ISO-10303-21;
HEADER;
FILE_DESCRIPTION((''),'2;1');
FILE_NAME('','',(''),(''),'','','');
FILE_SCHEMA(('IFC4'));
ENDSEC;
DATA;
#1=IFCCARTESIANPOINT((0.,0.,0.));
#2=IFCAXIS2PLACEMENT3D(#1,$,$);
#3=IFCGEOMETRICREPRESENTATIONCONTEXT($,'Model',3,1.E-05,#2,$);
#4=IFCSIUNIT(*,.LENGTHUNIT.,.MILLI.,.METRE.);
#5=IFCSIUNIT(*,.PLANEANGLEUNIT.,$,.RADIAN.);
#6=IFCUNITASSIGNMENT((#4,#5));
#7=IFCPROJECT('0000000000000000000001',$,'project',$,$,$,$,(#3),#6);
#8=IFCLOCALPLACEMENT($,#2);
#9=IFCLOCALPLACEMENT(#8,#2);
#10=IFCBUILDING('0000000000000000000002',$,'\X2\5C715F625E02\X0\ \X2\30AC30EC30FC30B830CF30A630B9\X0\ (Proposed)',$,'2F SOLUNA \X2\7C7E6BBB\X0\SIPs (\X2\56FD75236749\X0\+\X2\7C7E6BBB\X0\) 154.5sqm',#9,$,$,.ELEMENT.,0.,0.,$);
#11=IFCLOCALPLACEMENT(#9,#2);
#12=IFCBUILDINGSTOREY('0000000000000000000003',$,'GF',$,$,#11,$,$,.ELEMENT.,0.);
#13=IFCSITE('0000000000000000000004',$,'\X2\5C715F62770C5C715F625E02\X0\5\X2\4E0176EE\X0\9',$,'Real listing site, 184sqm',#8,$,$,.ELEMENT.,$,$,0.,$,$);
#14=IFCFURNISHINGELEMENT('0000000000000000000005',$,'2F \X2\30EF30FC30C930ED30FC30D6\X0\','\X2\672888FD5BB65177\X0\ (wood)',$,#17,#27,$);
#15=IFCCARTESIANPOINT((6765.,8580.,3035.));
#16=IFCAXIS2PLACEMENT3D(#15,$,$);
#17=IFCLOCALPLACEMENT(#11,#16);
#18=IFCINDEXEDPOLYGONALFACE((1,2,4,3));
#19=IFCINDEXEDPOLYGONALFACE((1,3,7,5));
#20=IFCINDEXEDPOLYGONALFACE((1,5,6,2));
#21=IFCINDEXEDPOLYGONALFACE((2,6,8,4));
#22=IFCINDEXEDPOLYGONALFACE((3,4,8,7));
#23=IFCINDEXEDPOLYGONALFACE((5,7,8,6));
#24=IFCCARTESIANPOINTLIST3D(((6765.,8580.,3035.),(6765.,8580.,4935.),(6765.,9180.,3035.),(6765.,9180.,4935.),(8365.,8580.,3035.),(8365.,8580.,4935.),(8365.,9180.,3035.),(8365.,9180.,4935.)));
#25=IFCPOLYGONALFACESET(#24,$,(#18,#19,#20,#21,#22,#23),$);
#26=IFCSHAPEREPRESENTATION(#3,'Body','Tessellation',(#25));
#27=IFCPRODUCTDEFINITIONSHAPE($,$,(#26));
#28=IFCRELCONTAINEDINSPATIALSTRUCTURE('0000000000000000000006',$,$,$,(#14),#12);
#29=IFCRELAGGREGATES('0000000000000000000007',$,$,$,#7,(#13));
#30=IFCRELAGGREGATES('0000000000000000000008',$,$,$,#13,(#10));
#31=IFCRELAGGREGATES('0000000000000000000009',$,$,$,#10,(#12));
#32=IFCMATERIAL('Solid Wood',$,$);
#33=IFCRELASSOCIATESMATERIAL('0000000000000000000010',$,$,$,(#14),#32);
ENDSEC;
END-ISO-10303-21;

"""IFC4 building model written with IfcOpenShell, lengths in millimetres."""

from ifc_helpers import new_model, si_unit, frame, frame_2d, origin, place, context, project, spatial, rectangle, extrude, material, element, save


model = new_model("IFC4")

# Units and contexts
model_context = context("Model", 3, precision=1e-05, world=origin())
ifc_project = project(units=[si_unit("LENGTHUNIT", "METRE", prefix="MILLI"), si_unit("PLANEANGLEUNIT", "RADIAN")], contexts=[model_context])

# Site, building, storey
site_placement = place(None, origin())
site = spatial("IfcSite", under=ifc_project, at=site_placement, Name="山形県山形市5丁目9", ObjectType="Real listing site, 184sqm", CompositionType="ELEMENT", RefElevation=0.0)
building_placement = place(site_placement, origin())
building = spatial("IfcBuilding", under=site, at=building_placement, Name="山形市 ガレージハウス (Proposed)", ObjectType="2F SOLUNA 籾殻SIPs (国産杉+籾殻) 154.5sqm", CompositionType="ELEMENT", ElevationOfRefHeight=0.0, ElevationOfTerrain=0.0)
storey_placement = place(building_placement, origin())
storey = spatial("IfcBuildingStorey", under=building, at=storey_placement, Name="GF", CompositionType="ELEMENT", Elevation=0.0)

# Shared definitions
ifc_material_1 = material(Name="Solid Wood")

# Furnishing element
furnishing_1_placement = place(storey_placement, frame((6765.0, 8580.0, 3035.0)))
element("IfcFurnishingElement", 1, at=furnishing_1_placement, inside=storey, material=ifc_material_1, Name="2F ワードローブ", Description="木製家具 (wood)", context=model_context, shape_type="SweptSolid", body=[
    extrude(rectangle(XDim=1600.0, YDim=600.0, at=frame_2d((800.0, 300.0))), frame((6765.0, 8580.0, 3035.0)), (0.0, 0.0, 1.0), 1900.0),
])

save(model, "model.ifc")
